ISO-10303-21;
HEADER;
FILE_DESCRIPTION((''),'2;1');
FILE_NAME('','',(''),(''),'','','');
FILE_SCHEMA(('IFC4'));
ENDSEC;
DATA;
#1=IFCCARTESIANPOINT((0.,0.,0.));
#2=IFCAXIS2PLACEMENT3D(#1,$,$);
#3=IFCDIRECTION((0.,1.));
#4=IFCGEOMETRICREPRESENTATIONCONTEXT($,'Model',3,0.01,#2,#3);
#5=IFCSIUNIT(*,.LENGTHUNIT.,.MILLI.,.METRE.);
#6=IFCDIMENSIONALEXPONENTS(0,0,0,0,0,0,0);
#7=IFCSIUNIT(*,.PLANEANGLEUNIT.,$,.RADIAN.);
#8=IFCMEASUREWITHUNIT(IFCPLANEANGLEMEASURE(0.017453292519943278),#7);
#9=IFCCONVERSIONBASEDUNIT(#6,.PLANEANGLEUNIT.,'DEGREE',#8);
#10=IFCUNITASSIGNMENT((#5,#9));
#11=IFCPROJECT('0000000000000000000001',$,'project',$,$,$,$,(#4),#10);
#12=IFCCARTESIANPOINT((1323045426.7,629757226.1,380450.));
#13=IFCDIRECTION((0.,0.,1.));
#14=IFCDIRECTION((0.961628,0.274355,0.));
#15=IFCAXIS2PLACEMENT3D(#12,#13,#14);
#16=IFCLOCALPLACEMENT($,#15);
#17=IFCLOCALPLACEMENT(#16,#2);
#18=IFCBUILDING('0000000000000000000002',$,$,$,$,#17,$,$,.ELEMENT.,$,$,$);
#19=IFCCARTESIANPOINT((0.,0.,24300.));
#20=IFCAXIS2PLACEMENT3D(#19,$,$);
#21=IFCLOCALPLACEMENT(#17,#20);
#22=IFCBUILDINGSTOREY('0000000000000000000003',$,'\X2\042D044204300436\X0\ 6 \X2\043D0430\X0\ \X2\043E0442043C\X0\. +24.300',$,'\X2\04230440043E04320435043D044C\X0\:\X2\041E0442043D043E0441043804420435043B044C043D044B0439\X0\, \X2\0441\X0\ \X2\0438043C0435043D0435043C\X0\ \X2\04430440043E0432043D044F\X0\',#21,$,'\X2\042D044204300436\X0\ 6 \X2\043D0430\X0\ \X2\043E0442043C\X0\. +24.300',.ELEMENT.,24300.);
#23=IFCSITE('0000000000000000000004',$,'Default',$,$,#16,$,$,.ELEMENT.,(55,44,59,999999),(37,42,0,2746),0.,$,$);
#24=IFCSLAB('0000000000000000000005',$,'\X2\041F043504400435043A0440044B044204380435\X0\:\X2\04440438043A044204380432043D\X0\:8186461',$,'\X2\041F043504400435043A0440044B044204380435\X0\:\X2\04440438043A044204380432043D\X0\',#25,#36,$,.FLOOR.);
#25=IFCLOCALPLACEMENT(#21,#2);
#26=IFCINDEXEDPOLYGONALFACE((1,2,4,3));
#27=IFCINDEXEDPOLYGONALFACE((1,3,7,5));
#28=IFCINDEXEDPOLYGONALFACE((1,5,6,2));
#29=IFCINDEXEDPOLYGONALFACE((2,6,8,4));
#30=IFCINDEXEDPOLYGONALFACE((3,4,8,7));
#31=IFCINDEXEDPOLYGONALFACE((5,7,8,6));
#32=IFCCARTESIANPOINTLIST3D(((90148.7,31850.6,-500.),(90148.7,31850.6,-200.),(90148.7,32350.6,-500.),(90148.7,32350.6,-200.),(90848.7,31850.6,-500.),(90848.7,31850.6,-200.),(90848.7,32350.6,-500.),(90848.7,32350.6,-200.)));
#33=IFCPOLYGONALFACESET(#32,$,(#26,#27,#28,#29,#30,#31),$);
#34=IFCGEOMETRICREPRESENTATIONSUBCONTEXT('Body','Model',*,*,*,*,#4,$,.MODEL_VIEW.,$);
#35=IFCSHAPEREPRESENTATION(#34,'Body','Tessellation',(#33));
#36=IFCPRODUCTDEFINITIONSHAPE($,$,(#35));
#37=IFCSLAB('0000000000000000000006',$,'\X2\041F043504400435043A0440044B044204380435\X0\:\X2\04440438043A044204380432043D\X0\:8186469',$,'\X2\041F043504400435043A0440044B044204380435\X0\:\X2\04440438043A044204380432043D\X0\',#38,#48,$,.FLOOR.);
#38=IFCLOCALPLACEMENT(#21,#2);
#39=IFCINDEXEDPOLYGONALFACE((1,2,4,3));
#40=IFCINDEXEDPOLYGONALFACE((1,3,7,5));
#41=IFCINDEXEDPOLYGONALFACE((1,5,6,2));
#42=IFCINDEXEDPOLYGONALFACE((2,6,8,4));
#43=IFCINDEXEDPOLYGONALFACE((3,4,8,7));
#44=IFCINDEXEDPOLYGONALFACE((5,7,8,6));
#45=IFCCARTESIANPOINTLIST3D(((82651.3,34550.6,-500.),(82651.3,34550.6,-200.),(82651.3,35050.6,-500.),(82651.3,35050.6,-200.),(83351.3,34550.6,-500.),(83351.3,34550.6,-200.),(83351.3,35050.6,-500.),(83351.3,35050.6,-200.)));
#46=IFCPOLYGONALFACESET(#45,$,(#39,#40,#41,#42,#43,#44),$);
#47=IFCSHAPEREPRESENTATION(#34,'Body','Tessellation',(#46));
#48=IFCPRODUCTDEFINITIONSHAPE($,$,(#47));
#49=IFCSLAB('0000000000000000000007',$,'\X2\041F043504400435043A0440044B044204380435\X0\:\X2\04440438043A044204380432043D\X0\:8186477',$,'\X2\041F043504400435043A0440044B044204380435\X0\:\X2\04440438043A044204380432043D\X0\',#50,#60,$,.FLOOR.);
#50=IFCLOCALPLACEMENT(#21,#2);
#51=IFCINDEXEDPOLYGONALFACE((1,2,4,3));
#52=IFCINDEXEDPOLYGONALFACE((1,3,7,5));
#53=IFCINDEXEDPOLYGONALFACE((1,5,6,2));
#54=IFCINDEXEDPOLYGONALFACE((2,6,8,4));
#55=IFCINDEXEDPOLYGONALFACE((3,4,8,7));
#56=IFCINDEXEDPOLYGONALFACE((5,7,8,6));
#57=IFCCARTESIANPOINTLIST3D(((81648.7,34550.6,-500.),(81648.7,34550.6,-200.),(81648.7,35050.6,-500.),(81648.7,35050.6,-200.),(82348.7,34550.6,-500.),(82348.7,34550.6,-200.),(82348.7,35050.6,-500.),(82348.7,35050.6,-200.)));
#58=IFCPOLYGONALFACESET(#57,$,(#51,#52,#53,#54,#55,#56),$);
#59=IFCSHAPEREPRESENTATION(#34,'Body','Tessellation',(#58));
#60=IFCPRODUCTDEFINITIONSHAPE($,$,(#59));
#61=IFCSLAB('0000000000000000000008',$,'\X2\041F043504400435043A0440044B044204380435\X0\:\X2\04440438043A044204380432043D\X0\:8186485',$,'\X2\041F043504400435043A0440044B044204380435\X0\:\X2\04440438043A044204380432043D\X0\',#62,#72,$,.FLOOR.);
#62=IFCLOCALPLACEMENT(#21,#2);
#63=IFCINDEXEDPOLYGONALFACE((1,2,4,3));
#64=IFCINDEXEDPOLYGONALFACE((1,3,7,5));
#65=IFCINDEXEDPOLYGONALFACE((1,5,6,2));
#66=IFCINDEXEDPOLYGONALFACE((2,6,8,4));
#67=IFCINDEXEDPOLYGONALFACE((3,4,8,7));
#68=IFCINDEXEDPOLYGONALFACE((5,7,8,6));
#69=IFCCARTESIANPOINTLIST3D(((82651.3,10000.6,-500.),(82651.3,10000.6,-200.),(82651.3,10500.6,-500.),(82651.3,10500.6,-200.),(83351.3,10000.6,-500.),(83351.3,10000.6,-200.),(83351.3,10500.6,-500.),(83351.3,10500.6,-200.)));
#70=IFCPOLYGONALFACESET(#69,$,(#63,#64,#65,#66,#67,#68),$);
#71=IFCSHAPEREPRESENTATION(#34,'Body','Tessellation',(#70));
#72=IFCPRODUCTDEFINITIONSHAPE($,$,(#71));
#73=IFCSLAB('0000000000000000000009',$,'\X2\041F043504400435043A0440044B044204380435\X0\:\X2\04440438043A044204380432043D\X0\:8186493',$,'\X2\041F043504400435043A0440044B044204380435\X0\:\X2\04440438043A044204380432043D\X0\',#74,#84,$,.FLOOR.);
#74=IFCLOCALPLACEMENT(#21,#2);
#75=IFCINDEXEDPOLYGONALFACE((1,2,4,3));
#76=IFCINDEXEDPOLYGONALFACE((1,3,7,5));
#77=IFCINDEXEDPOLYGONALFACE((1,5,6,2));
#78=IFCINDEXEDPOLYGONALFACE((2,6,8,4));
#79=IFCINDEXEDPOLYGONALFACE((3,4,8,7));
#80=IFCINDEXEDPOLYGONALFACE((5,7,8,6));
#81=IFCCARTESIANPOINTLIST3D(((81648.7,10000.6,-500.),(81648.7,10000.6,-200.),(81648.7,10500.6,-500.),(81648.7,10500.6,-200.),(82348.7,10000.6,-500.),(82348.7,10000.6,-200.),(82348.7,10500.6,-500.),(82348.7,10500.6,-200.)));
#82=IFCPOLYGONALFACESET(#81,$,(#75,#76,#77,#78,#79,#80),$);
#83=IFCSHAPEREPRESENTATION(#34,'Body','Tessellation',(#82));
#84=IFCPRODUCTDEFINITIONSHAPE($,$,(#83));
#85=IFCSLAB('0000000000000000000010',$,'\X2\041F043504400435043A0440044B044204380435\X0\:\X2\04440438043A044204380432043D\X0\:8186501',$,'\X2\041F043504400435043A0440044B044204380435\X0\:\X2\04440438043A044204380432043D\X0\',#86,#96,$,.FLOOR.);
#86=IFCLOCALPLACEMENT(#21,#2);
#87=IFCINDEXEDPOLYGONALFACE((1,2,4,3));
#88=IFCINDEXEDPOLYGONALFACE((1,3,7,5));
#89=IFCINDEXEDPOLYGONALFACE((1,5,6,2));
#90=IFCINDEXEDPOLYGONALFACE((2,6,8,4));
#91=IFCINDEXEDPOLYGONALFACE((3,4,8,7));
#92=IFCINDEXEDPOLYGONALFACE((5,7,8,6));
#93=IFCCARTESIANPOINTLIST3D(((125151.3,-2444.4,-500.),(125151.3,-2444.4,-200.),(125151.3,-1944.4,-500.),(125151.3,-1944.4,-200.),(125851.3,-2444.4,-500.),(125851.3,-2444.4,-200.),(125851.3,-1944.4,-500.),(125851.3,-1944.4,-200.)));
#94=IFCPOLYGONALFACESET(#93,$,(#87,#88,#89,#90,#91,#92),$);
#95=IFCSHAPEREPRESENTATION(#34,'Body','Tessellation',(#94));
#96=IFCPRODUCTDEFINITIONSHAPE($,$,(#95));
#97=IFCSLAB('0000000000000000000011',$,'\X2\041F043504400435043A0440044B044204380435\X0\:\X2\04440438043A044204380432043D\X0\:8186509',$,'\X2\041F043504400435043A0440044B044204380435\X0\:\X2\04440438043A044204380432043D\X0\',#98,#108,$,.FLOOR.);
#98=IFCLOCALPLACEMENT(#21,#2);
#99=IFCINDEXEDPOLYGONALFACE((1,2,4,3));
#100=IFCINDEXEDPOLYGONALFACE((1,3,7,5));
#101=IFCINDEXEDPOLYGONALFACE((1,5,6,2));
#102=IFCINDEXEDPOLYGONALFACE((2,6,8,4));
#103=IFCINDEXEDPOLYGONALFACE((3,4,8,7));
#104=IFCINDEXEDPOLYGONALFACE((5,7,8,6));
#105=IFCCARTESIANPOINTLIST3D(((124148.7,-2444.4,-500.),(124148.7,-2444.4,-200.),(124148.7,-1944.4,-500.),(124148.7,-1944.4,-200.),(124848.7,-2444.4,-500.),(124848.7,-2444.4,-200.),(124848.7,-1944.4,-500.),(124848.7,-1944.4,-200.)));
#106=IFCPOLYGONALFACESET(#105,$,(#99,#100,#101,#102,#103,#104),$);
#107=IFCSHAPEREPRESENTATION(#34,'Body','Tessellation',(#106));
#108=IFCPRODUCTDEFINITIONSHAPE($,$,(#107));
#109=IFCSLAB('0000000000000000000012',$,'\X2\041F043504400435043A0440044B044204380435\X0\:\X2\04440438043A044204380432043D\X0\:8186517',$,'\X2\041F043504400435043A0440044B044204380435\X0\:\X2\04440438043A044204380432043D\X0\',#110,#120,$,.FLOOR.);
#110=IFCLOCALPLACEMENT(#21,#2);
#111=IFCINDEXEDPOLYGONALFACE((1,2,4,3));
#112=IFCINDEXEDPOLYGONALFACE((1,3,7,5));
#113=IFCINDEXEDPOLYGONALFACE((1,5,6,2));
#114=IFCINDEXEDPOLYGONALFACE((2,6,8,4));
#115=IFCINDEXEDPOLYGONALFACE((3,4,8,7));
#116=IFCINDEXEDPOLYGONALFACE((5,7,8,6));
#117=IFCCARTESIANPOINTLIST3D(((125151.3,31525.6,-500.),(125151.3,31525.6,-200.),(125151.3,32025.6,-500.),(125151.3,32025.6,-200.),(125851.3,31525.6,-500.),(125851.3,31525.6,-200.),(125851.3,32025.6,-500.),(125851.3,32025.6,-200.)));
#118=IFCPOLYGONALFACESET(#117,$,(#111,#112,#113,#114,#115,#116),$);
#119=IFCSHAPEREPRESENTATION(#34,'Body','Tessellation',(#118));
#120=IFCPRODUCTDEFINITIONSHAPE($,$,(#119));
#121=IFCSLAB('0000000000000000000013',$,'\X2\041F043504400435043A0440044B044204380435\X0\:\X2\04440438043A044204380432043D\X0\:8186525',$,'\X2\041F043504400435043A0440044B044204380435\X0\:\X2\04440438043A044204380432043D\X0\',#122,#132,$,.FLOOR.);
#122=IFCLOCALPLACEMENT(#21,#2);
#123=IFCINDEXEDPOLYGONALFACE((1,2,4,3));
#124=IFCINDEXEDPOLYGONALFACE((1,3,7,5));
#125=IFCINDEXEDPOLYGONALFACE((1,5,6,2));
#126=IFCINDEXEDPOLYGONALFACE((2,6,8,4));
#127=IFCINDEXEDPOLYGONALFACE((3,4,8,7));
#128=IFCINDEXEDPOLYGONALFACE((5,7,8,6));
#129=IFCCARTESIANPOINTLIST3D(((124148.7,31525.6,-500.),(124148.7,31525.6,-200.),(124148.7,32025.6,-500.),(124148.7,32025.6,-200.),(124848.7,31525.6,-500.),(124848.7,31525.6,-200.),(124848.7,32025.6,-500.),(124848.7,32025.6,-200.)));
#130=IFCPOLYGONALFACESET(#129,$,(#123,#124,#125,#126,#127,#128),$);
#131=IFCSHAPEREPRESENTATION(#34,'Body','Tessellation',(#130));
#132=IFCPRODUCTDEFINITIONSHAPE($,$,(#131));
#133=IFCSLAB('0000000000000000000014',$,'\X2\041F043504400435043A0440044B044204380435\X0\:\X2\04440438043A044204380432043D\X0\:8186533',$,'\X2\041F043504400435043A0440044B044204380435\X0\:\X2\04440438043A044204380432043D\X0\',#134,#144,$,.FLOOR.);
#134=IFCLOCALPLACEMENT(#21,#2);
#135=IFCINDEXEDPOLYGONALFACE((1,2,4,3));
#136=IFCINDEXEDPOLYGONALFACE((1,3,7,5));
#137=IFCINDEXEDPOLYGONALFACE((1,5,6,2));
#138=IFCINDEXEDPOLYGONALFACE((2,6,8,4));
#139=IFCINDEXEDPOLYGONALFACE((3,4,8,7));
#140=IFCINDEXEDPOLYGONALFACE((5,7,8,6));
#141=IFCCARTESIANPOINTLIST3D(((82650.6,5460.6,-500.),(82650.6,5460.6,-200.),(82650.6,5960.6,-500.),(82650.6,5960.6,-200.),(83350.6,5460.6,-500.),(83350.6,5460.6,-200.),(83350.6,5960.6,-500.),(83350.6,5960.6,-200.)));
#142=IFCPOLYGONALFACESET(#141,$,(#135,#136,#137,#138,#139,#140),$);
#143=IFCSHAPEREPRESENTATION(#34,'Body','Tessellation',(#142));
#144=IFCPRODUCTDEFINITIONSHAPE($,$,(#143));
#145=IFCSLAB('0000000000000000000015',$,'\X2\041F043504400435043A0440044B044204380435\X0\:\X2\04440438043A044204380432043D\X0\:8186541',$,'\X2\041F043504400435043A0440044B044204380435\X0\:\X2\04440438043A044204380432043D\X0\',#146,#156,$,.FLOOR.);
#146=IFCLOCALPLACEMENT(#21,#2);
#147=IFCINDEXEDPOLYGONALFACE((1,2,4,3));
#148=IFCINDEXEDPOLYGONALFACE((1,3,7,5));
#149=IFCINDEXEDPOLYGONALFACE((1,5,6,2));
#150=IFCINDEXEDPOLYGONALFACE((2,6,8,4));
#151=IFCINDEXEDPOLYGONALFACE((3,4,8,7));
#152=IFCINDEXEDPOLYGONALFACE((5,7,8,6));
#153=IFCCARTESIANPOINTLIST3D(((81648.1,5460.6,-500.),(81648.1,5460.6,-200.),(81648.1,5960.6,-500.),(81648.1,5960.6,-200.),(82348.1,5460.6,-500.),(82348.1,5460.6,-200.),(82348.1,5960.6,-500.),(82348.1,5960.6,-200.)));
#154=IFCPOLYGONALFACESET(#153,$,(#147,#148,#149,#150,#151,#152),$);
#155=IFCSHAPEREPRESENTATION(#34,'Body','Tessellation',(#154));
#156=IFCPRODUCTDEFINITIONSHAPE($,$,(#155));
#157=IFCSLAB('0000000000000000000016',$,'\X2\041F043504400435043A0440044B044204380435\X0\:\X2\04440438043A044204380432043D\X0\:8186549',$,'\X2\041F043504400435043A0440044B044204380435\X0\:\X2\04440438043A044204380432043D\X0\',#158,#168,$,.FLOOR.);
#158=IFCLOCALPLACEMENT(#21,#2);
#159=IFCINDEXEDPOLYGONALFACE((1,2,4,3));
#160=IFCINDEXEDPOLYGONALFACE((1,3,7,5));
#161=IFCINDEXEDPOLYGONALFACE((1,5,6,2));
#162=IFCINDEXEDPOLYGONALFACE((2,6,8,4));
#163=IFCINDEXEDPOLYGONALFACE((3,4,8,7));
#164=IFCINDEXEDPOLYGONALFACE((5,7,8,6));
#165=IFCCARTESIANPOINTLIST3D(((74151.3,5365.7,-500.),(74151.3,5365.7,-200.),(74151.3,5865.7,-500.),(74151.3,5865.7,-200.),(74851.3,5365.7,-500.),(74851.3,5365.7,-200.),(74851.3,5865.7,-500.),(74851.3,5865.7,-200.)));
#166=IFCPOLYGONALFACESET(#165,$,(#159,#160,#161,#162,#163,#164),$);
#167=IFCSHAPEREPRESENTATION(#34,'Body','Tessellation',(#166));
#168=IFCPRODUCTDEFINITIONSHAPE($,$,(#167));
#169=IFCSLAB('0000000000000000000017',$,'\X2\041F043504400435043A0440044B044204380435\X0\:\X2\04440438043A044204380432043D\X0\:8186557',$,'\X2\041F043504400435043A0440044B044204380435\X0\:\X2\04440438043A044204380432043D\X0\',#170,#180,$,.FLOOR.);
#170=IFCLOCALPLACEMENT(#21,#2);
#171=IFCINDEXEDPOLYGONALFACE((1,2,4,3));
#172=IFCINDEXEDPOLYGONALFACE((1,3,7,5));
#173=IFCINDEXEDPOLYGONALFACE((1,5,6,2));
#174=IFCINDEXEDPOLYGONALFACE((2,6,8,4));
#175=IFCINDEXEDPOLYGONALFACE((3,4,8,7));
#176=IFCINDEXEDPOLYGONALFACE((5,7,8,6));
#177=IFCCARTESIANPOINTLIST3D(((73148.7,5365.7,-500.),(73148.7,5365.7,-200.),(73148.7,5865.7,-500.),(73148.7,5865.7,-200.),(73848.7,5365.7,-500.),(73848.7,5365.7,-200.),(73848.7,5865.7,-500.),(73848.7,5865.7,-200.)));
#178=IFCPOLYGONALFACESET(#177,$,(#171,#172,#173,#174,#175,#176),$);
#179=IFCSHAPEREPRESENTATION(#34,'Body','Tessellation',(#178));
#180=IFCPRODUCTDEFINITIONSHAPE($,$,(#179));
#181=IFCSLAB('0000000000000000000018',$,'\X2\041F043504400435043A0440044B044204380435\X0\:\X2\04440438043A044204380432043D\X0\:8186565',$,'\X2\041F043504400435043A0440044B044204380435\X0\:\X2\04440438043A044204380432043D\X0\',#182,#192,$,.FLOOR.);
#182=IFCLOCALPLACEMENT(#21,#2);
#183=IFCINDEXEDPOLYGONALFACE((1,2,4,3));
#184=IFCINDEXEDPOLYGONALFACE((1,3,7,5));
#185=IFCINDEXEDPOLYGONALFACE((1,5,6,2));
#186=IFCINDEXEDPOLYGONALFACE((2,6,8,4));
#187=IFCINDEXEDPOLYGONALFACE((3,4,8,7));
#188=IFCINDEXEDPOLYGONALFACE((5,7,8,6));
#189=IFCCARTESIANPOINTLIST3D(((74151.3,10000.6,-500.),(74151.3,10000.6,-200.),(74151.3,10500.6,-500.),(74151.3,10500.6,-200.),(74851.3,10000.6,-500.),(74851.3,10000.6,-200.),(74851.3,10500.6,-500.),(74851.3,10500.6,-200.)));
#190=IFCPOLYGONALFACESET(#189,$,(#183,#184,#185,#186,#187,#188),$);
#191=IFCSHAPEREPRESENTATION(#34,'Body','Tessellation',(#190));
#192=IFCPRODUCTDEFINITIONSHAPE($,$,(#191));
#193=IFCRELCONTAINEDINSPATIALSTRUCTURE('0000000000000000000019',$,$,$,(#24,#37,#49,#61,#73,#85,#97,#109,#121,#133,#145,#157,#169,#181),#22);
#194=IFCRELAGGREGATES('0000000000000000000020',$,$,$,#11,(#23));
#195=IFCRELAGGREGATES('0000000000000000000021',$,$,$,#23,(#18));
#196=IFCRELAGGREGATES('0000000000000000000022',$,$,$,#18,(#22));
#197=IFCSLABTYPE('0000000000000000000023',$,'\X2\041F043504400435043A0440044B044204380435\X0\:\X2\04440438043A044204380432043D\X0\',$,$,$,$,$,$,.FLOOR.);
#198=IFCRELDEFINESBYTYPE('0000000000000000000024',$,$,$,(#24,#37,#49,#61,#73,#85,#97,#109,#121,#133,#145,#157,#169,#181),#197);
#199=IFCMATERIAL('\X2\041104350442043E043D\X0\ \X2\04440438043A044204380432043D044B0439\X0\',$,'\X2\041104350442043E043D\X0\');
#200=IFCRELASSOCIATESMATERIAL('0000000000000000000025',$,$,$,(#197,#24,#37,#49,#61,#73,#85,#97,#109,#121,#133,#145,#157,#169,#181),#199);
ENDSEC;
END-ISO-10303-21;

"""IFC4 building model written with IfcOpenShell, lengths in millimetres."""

from ifc_helpers import new_model, entity, si_unit, converted_unit, direction, frame, origin, place, context, subcontext, project, spatial, indexed_curve, outline, extrude, material, type_object, element, save


model = new_model("IFC4")

# Units and contexts
model_context = context("Model", 3, precision=0.01, world=origin(), true_north=direction((0.0, 1.0)))
body_context = subcontext(model_context, "Body", "Model", "MODEL_VIEW")
ifc_project = project(units=[si_unit("LENGTHUNIT", "METRE", prefix="MILLI"), converted_unit("PLANEANGLEUNIT", "DEGREE", entity("IfcPlaneAngleMeasure", 0.017453292519943278), si_unit("PLANEANGLEUNIT", "RADIAN"), dimensions=[0, 0, 0, 0, 0, 0, 0])], contexts=[model_context])

# Site, building, storey
site_placement = place(None, frame((1323045426.7, 629757226.1, 380450.0), z_axis=(0.0, 0.0, 1.0), x_axis=(0.961628, 0.274355, 0.0)))
site = spatial("IfcSite", under=ifc_project, at=site_placement, Name="Default", CompositionType="ELEMENT", RefLatitude=(55, 44, 59, 999999), RefLongitude=(37, 42, 0, 2746), RefElevation=0.0)
building_placement = place(site_placement, origin())
building = spatial("IfcBuilding", under=site, at=building_placement, CompositionType="ELEMENT")
storey_placement = place(building_placement, frame((0.0, 0.0, 24300.0)))
storey = spatial("IfcBuildingStorey", under=building, at=storey_placement, Name="Этаж 6 на отм. +24.300", ObjectType="Уровень:Относительный, с именем уровня", LongName="Этаж 6 на отм. +24.300", CompositionType="ELEMENT", Elevation=24300.0)

# Slabs
ifc_material_1 = material(Name="Бетон фиктивный", Category="Бетон")
slab_type_1 = type_object("IfcSlabType", Name="Перекрытие:фиктивн", PredefinedType="FLOOR", material=ifc_material_1)
slab_1_placement = place(storey_placement, origin())
element("IfcSlab", 1, at=slab_1_placement, inside=storey, type_object=slab_type_1, material=ifc_material_1, Name="Перекрытие:фиктивн:8186461", ObjectType="Перекрытие:фиктивн", PredefinedType="FLOOR", context=body_context, shape_type="SweptSolid", body=[
    extrude(outline(indexed_curve([(-250.0, -350.0), (250.0, -350.0), (250.0, 350.0), (-250.0, 350.0), (-250.0, -350.0)], self_intersect=False)), frame((90498.7, 32100.6, -200.0), z_axis=(0.0, 0.0, -1.0), x_axis=(0.0, 1.0, 0.0)), (0.0, 0.0, 1.0), 300.0),
])
slab_2_placement = place(storey_placement, origin())
element("IfcSlab", 2, at=slab_2_placement, inside=storey, type_object=slab_type_1, material=ifc_material_1, Name="Перекрытие:фиктивн:8186469", ObjectType="Перекрытие:фиктивн", PredefinedType="FLOOR", context=body_context, shape_type="SweptSolid", body=[
    extrude(outline(indexed_curve([(-250.0, -350.0), (250.0, -350.0), (250.0, 350.0), (-250.0, 350.0), (-250.0, -350.0)], self_intersect=False)), frame((83001.3, 34800.6, -200.0), z_axis=(0.0, 0.0, -1.0), x_axis=(0.0, 1.0, 0.0)), (0.0, 0.0, 1.0), 300.0),
])
slab_3_placement = place(storey_placement, origin())
element("IfcSlab", 3, at=slab_3_placement, inside=storey, type_object=slab_type_1, material=ifc_material_1, Name="Перекрытие:фиктивн:8186477", ObjectType="Перекрытие:фиктивн", PredefinedType="FLOOR", context=body_context, shape_type="SweptSolid", body=[
    extrude(outline(indexed_curve([(-250.0, -350.0), (250.0, -350.0), (250.0, 350.0), (-250.0, 350.0), (-250.0, -350.0)], self_intersect=False)), frame((81998.7, 34800.6, -200.0), z_axis=(0.0, 0.0, -1.0), x_axis=(0.0, 1.0, 0.0)), (0.0, 0.0, 1.0), 300.0),
])
slab_4_placement = place(storey_placement, origin())
element("IfcSlab", 4, at=slab_4_placement, inside=storey, type_object=slab_type_1, material=ifc_material_1, Name="Перекрытие:фиктивн:8186485", ObjectType="Перекрытие:фиктивн", PredefinedType="FLOOR", context=body_context, shape_type="SweptSolid", body=[
    extrude(outline(indexed_curve([(-250.0, -350.0), (250.0, -350.0), (250.0, 350.0), (-250.0, 350.0), (-250.0, -350.0)], self_intersect=False)), frame((83001.3, 10250.6, -200.0), z_axis=(0.0, 0.0, -1.0), x_axis=(0.0, 1.0, 0.0)), (0.0, 0.0, 1.0), 300.0),
])
slab_5_placement = place(storey_placement, origin())
element("IfcSlab", 5, at=slab_5_placement, inside=storey, type_object=slab_type_1, material=ifc_material_1, Name="Перекрытие:фиктивн:8186493", ObjectType="Перекрытие:фиктивн", PredefinedType="FLOOR", context=body_context, shape_type="SweptSolid", body=[
    extrude(outline(indexed_curve([(-250.0, -350.0), (250.0, -350.0), (250.0, 350.0), (-250.0, 350.0), (-250.0, -350.0)], self_intersect=False)), frame((81998.7, 10250.6, -200.0), z_axis=(0.0, 0.0, -1.0), x_axis=(0.0, 1.0, 0.0)), (0.0, 0.0, 1.0), 300.0),
])
slab_6_placement = place(storey_placement, origin())
element("IfcSlab", 6, at=slab_6_placement, inside=storey, type_object=slab_type_1, material=ifc_material_1, Name="Перекрытие:фиктивн:8186501", ObjectType="Перекрытие:фиктивн", PredefinedType="FLOOR", context=body_context, shape_type="SweptSolid", body=[
    extrude(outline(indexed_curve([(-250.0, -350.0), (250.0, -350.0), (250.0, 350.0), (-250.0, 350.0), (-250.0, -350.0)], self_intersect=False)), frame((125501.3, -2194.4, -200.0), z_axis=(0.0, 0.0, -1.0), x_axis=(0.0, 1.0, 0.0)), (0.0, 0.0, 1.0), 300.0),
])
slab_7_placement = place(storey_placement, origin())
element("IfcSlab", 7, at=slab_7_placement, inside=storey, type_object=slab_type_1, material=ifc_material_1, Name="Перекрытие:фиктивн:8186509", ObjectType="Перекрытие:фиктивн", PredefinedType="FLOOR", context=body_context, shape_type="SweptSolid", body=[
    extrude(outline(indexed_curve([(-250.0, -350.0), (250.0, -350.0), (250.0, 350.0), (-250.0, 350.0), (-250.0, -350.0)], self_intersect=False)), frame((124498.7, -2194.4, -200.0), z_axis=(0.0, 0.0, -1.0), x_axis=(0.0, 1.0, 0.0)), (0.0, 0.0, 1.0), 300.0),
])
slab_8_placement = place(storey_placement, origin())
element("IfcSlab", 8, at=slab_8_placement, inside=storey, type_object=slab_type_1, material=ifc_material_1, Name="Перекрытие:фиктивн:8186517", ObjectType="Перекрытие:фиктивн", PredefinedType="FLOOR", context=body_context, shape_type="SweptSolid", body=[
    extrude(outline(indexed_curve([(-250.0, -350.0), (250.0, -350.0), (250.0, 350.0), (-250.0, 350.0), (-250.0, -350.0)], self_intersect=False)), frame((125501.3, 31775.6, -200.0), z_axis=(0.0, 0.0, -1.0), x_axis=(0.0, 1.0, 0.0)), (0.0, 0.0, 1.0), 300.0),
])
slab_9_placement = place(storey_placement, origin())
element("IfcSlab", 9, at=slab_9_placement, inside=storey, type_object=slab_type_1, material=ifc_material_1, Name="Перекрытие:фиктивн:8186525", ObjectType="Перекрытие:фиктивн", PredefinedType="FLOOR", context=body_context, shape_type="SweptSolid", body=[
    extrude(outline(indexed_curve([(-250.0, -350.0), (250.0, -350.0), (250.0, 350.0), (-250.0, 350.0), (-250.0, -350.0)], self_intersect=False)), frame((124498.7, 31775.6, -200.0), z_axis=(0.0, 0.0, -1.0), x_axis=(0.0, 1.0, 0.0)), (0.0, 0.0, 1.0), 300.0),
])
slab_10_placement = place(storey_placement, origin())
element("IfcSlab", 10, at=slab_10_placement, inside=storey, type_object=slab_type_1, material=ifc_material_1, Name="Перекрытие:фиктивн:8186533", ObjectType="Перекрытие:фиктивн", PredefinedType="FLOOR", context=body_context, shape_type="SweptSolid", body=[
    extrude(outline(indexed_curve([(-250.0, -350.0), (250.0, -350.0), (250.0, 350.0), (-250.0, 350.0), (-250.0, -350.0)], self_intersect=False)), frame((83000.6, 5710.6, -200.0), z_axis=(0.0, 0.0, -1.0), x_axis=(0.0, 1.0, 0.0)), (0.0, 0.0, 1.0), 300.0),
])
slab_11_placement = place(storey_placement, origin())
element("IfcSlab", 11, at=slab_11_placement, inside=storey, type_object=slab_type_1, material=ifc_material_1, Name="Перекрытие:фиктивн:8186541", ObjectType="Перекрытие:фиктивн", PredefinedType="FLOOR", context=body_context, shape_type="SweptSolid", body=[
    extrude(outline(indexed_curve([(-250.0, -350.0), (250.0, -350.0), (250.0, 350.0), (-250.0, 350.0), (-250.0, -350.0)], self_intersect=False)), frame((81998.1, 5710.6, -200.0), z_axis=(0.0, 0.0, -1.0), x_axis=(0.0, 1.0, 0.0)), (0.0, 0.0, 1.0), 300.0),
])
slab_12_placement = place(storey_placement, origin())
element("IfcSlab", 12, at=slab_12_placement, inside=storey, type_object=slab_type_1, material=ifc_material_1, Name="Перекрытие:фиктивн:8186549", ObjectType="Перекрытие:фиктивн", PredefinedType="FLOOR", context=body_context, shape_type="SweptSolid", body=[
    extrude(outline(indexed_curve([(-250.0, -350.0), (250.0, -350.0), (250.0, 350.0), (-250.0, 350.0), (-250.0, -350.0)], self_intersect=False)), frame((74501.3, 5615.7, -200.0), z_axis=(0.0, 0.0, -1.0), x_axis=(0.0, 1.0, 0.0)), (0.0, 0.0, 1.0), 300.0),
])
slab_13_placement = place(storey_placement, origin())
element("IfcSlab", 13, at=slab_13_placement, inside=storey, type_object=slab_type_1, material=ifc_material_1, Name="Перекрытие:фиктивн:8186557", ObjectType="Перекрытие:фиктивн", PredefinedType="FLOOR", context=body_context, shape_type="SweptSolid", body=[
    extrude(outline(indexed_curve([(-250.0, -350.0), (250.0, -350.0), (250.0, 350.0), (-250.0, 350.0), (-250.0, -350.0)], self_intersect=False)), frame((73498.7, 5615.7, -200.0), z_axis=(0.0, 0.0, -1.0), x_axis=(0.0, 1.0, 0.0)), (0.0, 0.0, 1.0), 300.0),
])
slab_14_placement = place(storey_placement, origin())
element("IfcSlab", 14, at=slab_14_placement, inside=storey, type_object=slab_type_1, material=ifc_material_1, Name="Перекрытие:фиктивн:8186565", ObjectType="Перекрытие:фиктивн", PredefinedType="FLOOR", context=body_context, shape_type="SweptSolid", body=[
    extrude(outline(indexed_curve([(-250.0, -350.0), (250.0, -350.0), (250.0, 350.0), (-250.0, 350.0), (-250.0, -350.0)], self_intersect=False)), frame((74501.3, 10250.6, -200.0), z_axis=(0.0, 0.0, -1.0), x_axis=(0.0, 1.0, 0.0)), (0.0, 0.0, 1.0), 300.0),
])

save(model, "model.ifc")
